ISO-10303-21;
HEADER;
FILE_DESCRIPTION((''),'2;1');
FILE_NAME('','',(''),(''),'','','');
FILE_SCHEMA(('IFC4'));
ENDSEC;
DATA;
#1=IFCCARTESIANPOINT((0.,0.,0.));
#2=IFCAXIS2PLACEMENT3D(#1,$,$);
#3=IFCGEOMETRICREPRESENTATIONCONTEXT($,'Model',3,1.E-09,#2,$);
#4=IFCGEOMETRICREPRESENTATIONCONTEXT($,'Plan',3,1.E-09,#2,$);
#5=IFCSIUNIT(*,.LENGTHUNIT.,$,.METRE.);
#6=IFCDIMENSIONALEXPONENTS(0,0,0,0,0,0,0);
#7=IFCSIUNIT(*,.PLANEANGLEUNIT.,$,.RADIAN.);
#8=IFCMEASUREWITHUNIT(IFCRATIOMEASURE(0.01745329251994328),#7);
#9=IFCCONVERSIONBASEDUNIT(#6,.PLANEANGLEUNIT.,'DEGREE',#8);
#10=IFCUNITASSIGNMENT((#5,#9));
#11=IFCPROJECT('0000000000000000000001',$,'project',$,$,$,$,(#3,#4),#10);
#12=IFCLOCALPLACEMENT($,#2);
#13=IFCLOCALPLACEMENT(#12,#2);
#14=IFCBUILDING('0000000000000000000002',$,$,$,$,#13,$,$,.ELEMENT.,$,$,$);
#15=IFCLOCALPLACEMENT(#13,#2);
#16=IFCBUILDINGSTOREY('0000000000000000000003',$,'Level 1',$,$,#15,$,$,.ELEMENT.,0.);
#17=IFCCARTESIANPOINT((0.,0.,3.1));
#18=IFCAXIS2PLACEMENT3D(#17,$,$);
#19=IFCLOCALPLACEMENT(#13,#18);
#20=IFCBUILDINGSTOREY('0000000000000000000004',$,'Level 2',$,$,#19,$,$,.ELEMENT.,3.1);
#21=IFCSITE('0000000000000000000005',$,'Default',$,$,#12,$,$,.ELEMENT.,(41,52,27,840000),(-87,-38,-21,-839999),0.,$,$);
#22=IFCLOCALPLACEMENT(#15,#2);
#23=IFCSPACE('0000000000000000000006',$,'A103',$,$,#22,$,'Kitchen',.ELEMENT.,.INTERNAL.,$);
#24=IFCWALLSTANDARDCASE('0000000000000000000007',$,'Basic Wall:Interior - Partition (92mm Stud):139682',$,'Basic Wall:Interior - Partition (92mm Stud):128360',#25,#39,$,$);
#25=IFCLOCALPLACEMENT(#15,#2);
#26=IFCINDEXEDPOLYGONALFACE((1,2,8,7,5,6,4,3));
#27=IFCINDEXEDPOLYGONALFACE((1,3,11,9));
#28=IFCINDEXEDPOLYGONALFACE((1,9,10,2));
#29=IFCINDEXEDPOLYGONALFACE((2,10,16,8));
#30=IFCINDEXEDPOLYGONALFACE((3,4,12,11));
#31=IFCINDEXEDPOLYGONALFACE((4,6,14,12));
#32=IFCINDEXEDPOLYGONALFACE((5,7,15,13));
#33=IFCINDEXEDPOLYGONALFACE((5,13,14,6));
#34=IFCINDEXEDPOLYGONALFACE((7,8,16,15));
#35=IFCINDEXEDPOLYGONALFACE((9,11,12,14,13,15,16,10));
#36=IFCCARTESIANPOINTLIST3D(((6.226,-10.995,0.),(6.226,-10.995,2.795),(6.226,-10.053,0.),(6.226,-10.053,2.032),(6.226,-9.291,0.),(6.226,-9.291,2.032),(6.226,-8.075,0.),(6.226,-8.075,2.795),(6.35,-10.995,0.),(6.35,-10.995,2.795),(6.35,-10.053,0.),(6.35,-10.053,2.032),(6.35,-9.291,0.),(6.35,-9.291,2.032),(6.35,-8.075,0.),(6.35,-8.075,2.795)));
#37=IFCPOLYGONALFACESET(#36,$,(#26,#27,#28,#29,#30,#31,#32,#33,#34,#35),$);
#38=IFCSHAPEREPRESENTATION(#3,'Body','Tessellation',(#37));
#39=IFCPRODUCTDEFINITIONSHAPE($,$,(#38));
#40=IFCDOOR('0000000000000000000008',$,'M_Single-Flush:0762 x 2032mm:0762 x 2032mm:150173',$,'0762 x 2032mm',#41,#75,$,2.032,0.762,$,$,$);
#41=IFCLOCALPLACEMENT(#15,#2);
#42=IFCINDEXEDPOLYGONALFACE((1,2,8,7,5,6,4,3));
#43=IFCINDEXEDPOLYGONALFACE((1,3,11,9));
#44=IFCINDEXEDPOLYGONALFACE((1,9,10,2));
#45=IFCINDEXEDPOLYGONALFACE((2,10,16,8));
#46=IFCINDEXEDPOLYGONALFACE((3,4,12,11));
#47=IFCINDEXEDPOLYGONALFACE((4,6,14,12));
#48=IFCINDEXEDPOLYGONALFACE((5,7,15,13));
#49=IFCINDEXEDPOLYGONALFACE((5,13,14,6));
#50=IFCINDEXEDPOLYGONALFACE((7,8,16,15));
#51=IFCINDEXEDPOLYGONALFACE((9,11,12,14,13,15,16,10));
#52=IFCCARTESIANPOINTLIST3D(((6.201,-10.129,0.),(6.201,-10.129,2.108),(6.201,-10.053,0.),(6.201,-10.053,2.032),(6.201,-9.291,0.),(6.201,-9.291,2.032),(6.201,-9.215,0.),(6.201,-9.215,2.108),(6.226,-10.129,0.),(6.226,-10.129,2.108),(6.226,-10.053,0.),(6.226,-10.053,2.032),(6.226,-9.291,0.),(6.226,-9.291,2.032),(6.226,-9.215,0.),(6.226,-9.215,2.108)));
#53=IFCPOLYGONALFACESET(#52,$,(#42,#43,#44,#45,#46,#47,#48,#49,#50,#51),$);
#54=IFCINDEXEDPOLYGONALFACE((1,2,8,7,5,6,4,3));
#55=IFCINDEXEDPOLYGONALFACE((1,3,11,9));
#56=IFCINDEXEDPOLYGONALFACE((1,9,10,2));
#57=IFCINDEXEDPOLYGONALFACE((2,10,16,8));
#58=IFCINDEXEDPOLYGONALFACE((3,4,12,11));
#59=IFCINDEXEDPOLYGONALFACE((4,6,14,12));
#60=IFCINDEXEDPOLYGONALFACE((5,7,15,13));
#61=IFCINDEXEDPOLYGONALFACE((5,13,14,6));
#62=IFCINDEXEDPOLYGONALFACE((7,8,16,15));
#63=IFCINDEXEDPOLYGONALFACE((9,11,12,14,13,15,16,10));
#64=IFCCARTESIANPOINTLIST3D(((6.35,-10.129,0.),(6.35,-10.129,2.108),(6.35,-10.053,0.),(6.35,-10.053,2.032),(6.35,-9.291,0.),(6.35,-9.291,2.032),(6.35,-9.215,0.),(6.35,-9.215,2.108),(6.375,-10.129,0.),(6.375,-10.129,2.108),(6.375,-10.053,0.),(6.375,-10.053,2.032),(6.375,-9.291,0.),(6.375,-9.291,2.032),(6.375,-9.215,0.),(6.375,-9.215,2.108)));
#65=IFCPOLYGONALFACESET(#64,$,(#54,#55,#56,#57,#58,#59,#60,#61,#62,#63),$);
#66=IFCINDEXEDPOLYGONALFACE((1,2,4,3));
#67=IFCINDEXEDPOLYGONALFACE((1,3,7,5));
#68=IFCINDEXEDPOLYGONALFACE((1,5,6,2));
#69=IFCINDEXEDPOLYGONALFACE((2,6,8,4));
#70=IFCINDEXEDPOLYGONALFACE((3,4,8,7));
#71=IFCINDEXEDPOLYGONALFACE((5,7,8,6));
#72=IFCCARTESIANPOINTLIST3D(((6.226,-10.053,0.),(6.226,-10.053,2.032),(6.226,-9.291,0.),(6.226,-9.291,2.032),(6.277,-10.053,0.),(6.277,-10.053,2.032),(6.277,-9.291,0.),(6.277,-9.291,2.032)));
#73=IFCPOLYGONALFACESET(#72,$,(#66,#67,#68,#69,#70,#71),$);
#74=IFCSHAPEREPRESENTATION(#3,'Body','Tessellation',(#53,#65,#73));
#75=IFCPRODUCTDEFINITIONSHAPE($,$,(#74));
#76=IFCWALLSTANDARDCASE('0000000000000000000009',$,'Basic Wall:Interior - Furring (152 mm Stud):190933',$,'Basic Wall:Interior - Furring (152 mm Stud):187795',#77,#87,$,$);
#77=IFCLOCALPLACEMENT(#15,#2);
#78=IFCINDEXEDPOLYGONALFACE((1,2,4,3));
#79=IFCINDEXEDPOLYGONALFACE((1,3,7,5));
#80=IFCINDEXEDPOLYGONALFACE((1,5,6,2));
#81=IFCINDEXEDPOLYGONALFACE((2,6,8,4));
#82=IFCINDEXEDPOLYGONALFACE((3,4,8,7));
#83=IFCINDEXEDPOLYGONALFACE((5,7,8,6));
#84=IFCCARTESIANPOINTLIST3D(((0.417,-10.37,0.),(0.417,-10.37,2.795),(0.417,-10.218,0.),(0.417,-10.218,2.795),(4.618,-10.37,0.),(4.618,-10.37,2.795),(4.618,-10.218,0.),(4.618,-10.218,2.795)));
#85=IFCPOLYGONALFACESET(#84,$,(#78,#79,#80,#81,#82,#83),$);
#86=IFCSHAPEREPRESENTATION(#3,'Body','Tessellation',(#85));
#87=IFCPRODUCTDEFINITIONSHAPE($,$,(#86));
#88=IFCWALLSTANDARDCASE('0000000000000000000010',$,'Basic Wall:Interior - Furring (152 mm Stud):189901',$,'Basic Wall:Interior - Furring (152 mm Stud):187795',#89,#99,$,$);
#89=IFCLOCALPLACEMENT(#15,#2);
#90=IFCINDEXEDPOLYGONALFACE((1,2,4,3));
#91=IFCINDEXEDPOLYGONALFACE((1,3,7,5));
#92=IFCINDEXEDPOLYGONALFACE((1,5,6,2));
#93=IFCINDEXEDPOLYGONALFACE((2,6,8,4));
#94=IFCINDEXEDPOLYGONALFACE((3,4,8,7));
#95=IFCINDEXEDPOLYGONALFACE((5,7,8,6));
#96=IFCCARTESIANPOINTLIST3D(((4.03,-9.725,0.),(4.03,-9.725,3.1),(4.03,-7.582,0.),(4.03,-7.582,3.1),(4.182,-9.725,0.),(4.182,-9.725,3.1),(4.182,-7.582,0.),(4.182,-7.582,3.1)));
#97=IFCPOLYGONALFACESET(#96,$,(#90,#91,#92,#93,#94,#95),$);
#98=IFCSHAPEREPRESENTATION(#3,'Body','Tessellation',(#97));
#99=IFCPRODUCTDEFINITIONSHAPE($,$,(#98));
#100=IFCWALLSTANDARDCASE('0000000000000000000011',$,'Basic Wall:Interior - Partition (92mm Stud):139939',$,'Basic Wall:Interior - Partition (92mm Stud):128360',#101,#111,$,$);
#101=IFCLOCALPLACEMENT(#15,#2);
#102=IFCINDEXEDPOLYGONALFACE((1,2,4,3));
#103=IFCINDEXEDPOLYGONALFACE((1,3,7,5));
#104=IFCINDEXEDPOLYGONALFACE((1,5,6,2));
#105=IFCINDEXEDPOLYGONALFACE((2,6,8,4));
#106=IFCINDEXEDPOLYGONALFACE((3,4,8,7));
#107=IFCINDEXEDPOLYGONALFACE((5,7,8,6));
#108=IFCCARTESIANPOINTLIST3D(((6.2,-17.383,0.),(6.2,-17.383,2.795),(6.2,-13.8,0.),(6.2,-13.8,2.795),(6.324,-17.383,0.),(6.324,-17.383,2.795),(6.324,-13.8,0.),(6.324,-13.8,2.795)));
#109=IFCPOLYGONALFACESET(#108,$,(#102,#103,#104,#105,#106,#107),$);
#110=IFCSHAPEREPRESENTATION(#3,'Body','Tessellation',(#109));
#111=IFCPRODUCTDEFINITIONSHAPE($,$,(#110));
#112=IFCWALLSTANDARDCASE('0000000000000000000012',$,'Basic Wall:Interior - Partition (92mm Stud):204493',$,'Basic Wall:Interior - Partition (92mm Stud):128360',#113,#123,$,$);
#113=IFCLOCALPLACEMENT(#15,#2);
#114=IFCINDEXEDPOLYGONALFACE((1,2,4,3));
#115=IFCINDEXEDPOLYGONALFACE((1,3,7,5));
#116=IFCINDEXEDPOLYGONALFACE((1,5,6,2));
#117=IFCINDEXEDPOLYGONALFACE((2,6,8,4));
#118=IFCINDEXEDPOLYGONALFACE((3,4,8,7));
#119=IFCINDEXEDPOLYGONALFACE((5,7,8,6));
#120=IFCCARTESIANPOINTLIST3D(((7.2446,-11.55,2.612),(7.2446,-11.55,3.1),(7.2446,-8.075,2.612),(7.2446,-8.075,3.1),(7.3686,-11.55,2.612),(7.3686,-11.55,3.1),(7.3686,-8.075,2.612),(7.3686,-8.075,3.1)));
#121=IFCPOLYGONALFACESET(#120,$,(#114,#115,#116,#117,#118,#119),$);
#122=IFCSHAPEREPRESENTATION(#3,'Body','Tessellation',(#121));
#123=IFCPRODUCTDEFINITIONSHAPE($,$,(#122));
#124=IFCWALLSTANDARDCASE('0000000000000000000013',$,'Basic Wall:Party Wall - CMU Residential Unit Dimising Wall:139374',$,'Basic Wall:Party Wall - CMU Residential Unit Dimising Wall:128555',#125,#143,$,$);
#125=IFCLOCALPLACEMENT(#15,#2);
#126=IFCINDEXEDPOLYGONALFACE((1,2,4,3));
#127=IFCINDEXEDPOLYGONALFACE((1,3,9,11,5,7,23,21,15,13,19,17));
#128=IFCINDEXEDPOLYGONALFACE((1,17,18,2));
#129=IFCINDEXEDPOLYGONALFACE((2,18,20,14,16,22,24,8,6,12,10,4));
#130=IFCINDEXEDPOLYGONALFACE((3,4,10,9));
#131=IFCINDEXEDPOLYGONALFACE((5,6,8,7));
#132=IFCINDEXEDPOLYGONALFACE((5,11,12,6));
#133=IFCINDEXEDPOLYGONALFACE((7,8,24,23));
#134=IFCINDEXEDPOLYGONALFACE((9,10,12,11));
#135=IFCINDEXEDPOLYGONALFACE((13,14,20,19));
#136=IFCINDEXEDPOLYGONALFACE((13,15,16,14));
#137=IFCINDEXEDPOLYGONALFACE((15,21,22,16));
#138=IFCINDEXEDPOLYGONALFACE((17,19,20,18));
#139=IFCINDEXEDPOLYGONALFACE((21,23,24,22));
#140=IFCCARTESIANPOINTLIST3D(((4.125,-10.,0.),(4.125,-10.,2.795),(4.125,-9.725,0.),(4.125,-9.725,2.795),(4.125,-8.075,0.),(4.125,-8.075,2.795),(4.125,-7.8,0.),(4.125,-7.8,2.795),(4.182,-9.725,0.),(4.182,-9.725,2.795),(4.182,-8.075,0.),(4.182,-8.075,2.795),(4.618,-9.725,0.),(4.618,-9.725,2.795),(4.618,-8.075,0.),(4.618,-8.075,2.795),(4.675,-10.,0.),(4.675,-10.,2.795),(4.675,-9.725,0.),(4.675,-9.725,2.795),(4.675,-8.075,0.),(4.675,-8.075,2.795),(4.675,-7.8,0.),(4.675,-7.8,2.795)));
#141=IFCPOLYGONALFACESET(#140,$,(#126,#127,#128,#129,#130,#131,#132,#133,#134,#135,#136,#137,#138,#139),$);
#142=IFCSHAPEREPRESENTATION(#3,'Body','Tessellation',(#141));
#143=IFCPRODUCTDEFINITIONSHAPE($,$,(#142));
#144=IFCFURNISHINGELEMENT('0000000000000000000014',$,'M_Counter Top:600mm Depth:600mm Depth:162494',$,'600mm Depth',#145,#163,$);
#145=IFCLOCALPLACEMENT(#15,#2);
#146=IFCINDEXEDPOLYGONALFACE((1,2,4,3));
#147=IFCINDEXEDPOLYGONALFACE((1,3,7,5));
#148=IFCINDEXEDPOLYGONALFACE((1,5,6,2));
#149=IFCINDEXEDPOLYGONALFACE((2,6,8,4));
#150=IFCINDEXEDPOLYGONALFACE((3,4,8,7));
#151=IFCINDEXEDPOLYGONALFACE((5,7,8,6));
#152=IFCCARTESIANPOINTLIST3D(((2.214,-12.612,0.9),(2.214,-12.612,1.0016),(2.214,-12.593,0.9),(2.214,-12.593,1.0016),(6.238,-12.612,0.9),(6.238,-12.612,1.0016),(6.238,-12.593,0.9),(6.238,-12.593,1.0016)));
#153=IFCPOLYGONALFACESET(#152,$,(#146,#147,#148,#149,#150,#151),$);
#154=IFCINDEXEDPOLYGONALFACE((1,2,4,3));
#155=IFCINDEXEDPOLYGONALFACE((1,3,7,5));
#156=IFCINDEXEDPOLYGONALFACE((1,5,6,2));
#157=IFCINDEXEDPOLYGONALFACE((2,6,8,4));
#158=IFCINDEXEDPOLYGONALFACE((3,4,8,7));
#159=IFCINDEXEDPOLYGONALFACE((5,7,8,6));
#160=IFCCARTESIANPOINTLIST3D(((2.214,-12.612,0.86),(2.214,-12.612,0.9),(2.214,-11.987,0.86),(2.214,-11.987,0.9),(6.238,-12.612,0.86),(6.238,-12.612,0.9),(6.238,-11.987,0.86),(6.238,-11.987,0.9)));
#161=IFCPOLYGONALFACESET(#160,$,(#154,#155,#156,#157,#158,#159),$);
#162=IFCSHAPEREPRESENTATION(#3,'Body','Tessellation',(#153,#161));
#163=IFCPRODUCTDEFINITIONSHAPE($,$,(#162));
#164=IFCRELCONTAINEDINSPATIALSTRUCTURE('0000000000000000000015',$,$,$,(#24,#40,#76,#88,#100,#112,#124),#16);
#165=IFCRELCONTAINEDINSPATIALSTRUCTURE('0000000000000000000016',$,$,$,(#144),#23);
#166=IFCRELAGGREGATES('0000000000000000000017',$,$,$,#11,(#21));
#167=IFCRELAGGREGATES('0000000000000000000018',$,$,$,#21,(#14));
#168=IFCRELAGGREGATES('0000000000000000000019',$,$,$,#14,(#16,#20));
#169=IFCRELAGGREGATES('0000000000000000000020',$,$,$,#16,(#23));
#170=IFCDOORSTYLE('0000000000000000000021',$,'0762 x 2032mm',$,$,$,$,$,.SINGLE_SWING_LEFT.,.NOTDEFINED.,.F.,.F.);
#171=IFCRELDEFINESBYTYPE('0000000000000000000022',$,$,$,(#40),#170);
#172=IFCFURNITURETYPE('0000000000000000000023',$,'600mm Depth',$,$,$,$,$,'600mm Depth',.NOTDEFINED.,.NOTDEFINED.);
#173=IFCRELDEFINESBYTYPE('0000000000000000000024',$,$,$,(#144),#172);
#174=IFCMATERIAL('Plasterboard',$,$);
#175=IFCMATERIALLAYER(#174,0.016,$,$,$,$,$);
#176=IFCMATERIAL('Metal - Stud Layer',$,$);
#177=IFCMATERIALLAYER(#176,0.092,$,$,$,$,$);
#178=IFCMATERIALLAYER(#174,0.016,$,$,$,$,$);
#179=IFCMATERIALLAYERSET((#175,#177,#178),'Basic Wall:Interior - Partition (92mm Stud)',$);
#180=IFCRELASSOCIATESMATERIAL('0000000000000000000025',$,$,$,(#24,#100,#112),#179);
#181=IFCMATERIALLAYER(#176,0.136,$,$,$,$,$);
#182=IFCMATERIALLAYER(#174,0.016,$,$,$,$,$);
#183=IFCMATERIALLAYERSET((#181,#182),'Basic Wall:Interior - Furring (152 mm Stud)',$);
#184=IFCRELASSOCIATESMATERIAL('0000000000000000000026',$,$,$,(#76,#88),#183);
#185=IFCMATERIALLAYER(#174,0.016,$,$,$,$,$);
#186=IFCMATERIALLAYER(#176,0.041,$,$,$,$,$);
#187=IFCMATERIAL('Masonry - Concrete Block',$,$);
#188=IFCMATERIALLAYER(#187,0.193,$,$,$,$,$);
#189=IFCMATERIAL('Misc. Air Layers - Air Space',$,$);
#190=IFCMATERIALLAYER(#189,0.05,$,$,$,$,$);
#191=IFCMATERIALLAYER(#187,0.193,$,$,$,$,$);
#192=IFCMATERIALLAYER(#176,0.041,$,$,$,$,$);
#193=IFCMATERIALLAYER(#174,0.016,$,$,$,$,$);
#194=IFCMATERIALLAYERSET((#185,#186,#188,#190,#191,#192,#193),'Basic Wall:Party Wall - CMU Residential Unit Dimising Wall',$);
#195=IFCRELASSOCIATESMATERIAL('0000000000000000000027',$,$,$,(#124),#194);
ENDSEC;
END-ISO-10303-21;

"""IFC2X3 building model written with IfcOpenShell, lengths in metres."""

from ifc_helpers import new_model, entity, si_unit, converted_unit, frame, frame_2d, origin, origin_2d_with_axis, place, context, project, spatial, polyline, rectangle, outline, extrude, clip, bounded_halfspace, source, transform, mapped, material, layer, layer_set, layer_usage, type_object, type_shapes, element, fill, save


model = new_model("IFC2X3")

# Units and contexts
model_context = context("Model", 3, precision=1e-09, world=origin())
plan_context = context("Plan", 3, precision=1e-09, world=origin())
ifc_project = project(units=[si_unit("LENGTHUNIT", "METRE"), converted_unit("PLANEANGLEUNIT", "DEGREE", entity("IfcRatioMeasure", 0.01745329251994328), si_unit("PLANEANGLEUNIT", "RADIAN"), dimensions=[0, 0, 0, 0, 0, 0, 0])], contexts=[model_context, plan_context])

# Site, building, storey
site_placement = place(None, origin())
site = spatial("IfcSite", under=ifc_project, at=site_placement, Name="Default", CompositionType="ELEMENT", RefLatitude=(41, 52, 27, 840000), RefLongitude=(-87, -38, -21, -839999), RefElevation=0.0)
building_placement = place(site_placement, origin())
building = spatial("IfcBuilding", under=site, at=building_placement, CompositionType="ELEMENT")
storey_1_placement = place(building_placement, origin())
storey_1 = spatial("IfcBuildingStorey", under=building, at=storey_1_placement, Name="Level 1", CompositionType="ELEMENT", Elevation=0.0)

# Shared definitions
ifc_material_1 = material(Name="Misc. Air Layers - Air Space")
ifc_material_2 = material(Name="Masonry - Concrete Block")
ifc_material_3 = material(Name="Metal - Stud Layer")
ifc_material_4 = material(Name="Plasterboard")

# Shared definitions
ifc_layer_1 = layer(ifc_material_4, 0.016)
ifc_layer_2 = layer(ifc_material_3, 0.041)
ifc_layer_3 = layer(ifc_material_2, 0.193)
ifc_layer_4 = layer(ifc_material_1, 0.05)
ifc_layer_5 = layer(ifc_material_2, 0.193)
ifc_layer_6 = layer(ifc_material_3, 0.041)
ifc_layer_7 = layer(ifc_material_4, 0.016)
ifc_layer_set_1 = layer_set([ifc_layer_1, ifc_layer_2, ifc_layer_3, ifc_layer_4, ifc_layer_5, ifc_layer_6, ifc_layer_7], Name="Basic Wall:Party Wall - CMU Residential Unit Dimising Wall")
ifc_layer_usage_1 = layer_usage(ifc_layer_set_1, "AXIS2", "NEGATIVE", 0.275)
ifc_layer_8 = layer(ifc_material_4, 0.016)
ifc_layer_9 = layer(ifc_material_3, 0.092)
ifc_layer_10 = layer(ifc_material_4, 0.016)
ifc_layer_set_2 = layer_set([ifc_layer_8, ifc_layer_9, ifc_layer_10], Name="Basic Wall:Interior - Partition (92mm Stud)")
ifc_layer_usage_2 = layer_usage(ifc_layer_set_2, "AXIS2", "NEGATIVE", 0.062)

# Shared definitions
storey_2_placement = place(building_placement, frame((0.0, 0.0, 3.1)))
storey_2 = spatial("IfcBuildingStorey", under=building, at=storey_2_placement, Name="Level 2", CompositionType="ELEMENT", Elevation=3.1)

# Wall, opening, door
wall_1_placement = place(storey_1_placement, frame((6.288, -10.995, 0.0), z_axis=(0.0, 0.0, 1.0), x_axis=(0.0, 1.0, 0.0)))
wall_1 = element("IfcWallStandardCase", 1, at=wall_1_placement, inside=storey_1, material=ifc_layer_usage_2, Name="Basic Wall:Interior - Partition (92mm Stud):139682", ObjectType="Basic Wall:Interior - Partition (92mm Stud):128360", context=model_context, shape_type="SweptSolid", body=[
    extrude(rectangle(XDim=2.92, YDim=0.124, at=frame_2d((1.46, 0.0), x_axis=(-1.0, 0.0))), origin(), (0.0, 0.0, 1.0), 2.795),
])
opening_1_placement = place(wall_1_placement, frame((0.942, -0.062, 0.0)))
opening_1 = element("IfcOpeningElement", 2, at=opening_1_placement, cuts=wall_1, ObjectType="Opening", context=model_context, shape_type="SweptSolid", body=[
    extrude(rectangle(XDim=0.762, YDim=2.032, at=frame_2d((1.016, 0.381), x_axis=(0.0, -1.0))), frame((0.0, 0.0, 0.0), z_axis=(0.0, 1.0, 0.0), x_axis=(0.0, 0.0, 1.0)), (0.0, 0.0, 1.0), 0.124),
])
door_style_1 = type_object("IfcDoorStyle", Name="0762 x 2032mm", ConstructionType="NOTDEFINED", OperationType="SINGLE_SWING_LEFT", ParameterTakesPrecedence=False, Sizeable=False)
shared_shape_1 = source(origin(), model_context, "Body", "SweptSolid", [
    extrude(outline(polyline([(-0.457, -1.073), (0.457, -1.073), (0.457, 1.035), (0.381, 1.035), (0.381, -0.997), (-0.381, -0.997), (-0.381, 1.035), (-0.457, 1.035), (-0.457, -1.073)])), frame((0.381, 0.149, 1.035), z_axis=(0.0, -1.0, 0.0), x_axis=(-1.0, 0.0, 0.0)), (0.0, 0.0, 1.0), 0.025),
    extrude(outline(polyline([(-1.073, -0.457), (1.035, -0.457), (1.035, -0.381), (-0.997, -0.381), (-0.997, 0.381), (1.035, 0.381), (1.035, 0.457), (-1.073, 0.457), (-1.073, -0.457)])), frame((0.381, 0.0, 1.035), z_axis=(0.0, -1.0, 0.0), x_axis=(0.0, 0.0, -1.0)), (0.0, 0.0, 1.0), 0.025),
    extrude(rectangle(XDim=0.762, YDim=0.051, at=origin_2d_with_axis()), frame((0.381, 0.0985, 0.0)), (0.0, 0.0, 1.0), 2.032),
])
type_shapes(door_style_1, [shared_shape_1])
door_1_placement = place(opening_1_placement, origin())
door_1 = element("IfcDoor", 3, at=door_1_placement, inside=storey_1, type_object=door_style_1, Name="M_Single-Flush:0762 x 2032mm:0762 x 2032mm:150173", ObjectType="0762 x 2032mm", OverallHeight=2.032, OverallWidth=0.762, context=model_context, shape_type="MappedRepresentation", body=[
    mapped(shared_shape_1, transform((0.0, 0.0, 0.0), scale=1.0)),
])
fill(opening_1, door_1)

# Walls
ifc_layer_11 = layer(ifc_material_3, 0.136)
ifc_layer_12 = layer(ifc_material_4, 0.016)
ifc_layer_set_3 = layer_set([ifc_layer_11, ifc_layer_12], Name="Basic Wall:Interior - Furring (152 mm Stud)")
ifc_layer_usage_3 = layer_usage(ifc_layer_set_3, "AXIS2", "NEGATIVE", 0.076)
wall_2_placement = place(storey_1_placement, frame((0.417, -10.294, 0.0)))
element("IfcWallStandardCase", 4, at=wall_2_placement, inside=storey_1, material=ifc_layer_usage_3, Name="Basic Wall:Interior - Furring (152 mm Stud):190933", ObjectType="Basic Wall:Interior - Furring (152 mm Stud):187795", context=model_context, shape_type="SweptSolid", body=[
    extrude(rectangle(XDim=4.201, YDim=0.152, at=frame_2d((2.1005, 0.0), x_axis=(-1.0, 0.0))), origin(), (0.0, 0.0, 1.0), 2.795),
])
ifc_layer_usage_4 = layer_usage(ifc_layer_set_3, "AXIS2", "POSITIVE", -0.076)
wall_3_placement = place(storey_1_placement, frame((4.106, -9.725, 0.0), z_axis=(0.0, 0.0, 1.0), x_axis=(0.0, 1.0, 0.0)))
element("IfcWallStandardCase", 5, at=wall_3_placement, inside=storey_1, material=ifc_layer_usage_4, Name="Basic Wall:Interior - Furring (152 mm Stud):189901", ObjectType="Basic Wall:Interior - Furring (152 mm Stud):187795", context=model_context, shape_type="SweptSolid", body=[
    extrude(rectangle(XDim=2.143, YDim=0.152, at=frame_2d((1.0715, 0.0), x_axis=(-1.0, 0.0))), origin(), (0.0, 0.0, 1.0), 3.1),
])
wall_4_placement = place(storey_1_placement, frame((6.262, -13.8, 0.0), z_axis=(0.0, 0.0, 1.0), x_axis=(0.0, -1.0, 0.0)))
element("IfcWallStandardCase", 6, at=wall_4_placement, inside=storey_1, material=ifc_layer_usage_2, Name="Basic Wall:Interior - Partition (92mm Stud):139939", ObjectType="Basic Wall:Interior - Partition (92mm Stud):128360", context=model_context, shape_type="SweptSolid", body=[
    extrude(rectangle(XDim=3.583, YDim=0.124, at=frame_2d((1.7915, 0.0), x_axis=(-1.0, 0.0))), origin(), (0.0, 0.0, 1.0), 2.795),
])
wall_5_placement = place(storey_1_placement, frame((7.3066, -11.55, 2.612), z_axis=(0.0, 0.0, 1.0), x_axis=(0.0, 1.0, 0.0)))
element("IfcWallStandardCase", 7, at=wall_5_placement, inside=storey_1, material=ifc_layer_usage_2, Name="Basic Wall:Interior - Partition (92mm Stud):204493", ObjectType="Basic Wall:Interior - Partition (92mm Stud):128360", context=model_context, shape_type="SweptSolid", body=[
    extrude(rectangle(XDim=3.475, YDim=0.124, at=frame_2d((1.7375, 0.0), x_axis=(-1.0, 0.0))), origin(), (0.0, 0.0, 1.0), 0.488),
])
wall_6_placement = place(storey_1_placement, frame((4.4, -10.0, 0.0), z_axis=(0.0, 0.0, 1.0), x_axis=(0.0, 1.0, 0.0)))
element("IfcWallStandardCase", 8, at=wall_6_placement, inside=storey_1, material=ifc_layer_usage_1, Name="Basic Wall:Party Wall - CMU Residential Unit Dimising Wall:139374", ObjectType="Basic Wall:Party Wall - CMU Residential Unit Dimising Wall:128555", context=model_context, shape_type="Clipping", body=[
    clip(clip(extrude(rectangle(XDim=2.2, YDim=0.55, at=frame_2d((1.1, 0.0), x_axis=(-1.0, 0.0))), origin(), (0.0, 0.0, 1.0), 2.795), bounded_halfspace(frame((1.925, 0.218, 0.0), z_axis=(0.0, -1.0, 0.0), x_axis=(1.0, 0.0, 0.0)), True, frame((1.925, 0.218, 0.0), z_axis=(0.0, -1.0, 0.0), x_axis=(1.0, 0.0, 0.0)), polyline([(0.0, 0.0), (0.0, 2.795), (-1.65, 2.795), (-1.65, 0.0), (0.0, 0.0)]))), bounded_halfspace(frame((0.275, -0.218, 0.0), z_axis=(0.0, 1.0, 0.0), x_axis=(-1.0, 0.0, 0.0)), True, frame((0.275, -0.218, 0.0), z_axis=(0.0, 1.0, 0.0), x_axis=(-1.0, 0.0, 0.0)), polyline([(0.0, 0.0), (0.0, 2.795), (-1.65, 2.795), (-1.65, 0.0), (0.0, 0.0)]))),
])

# Shared definitions
space_1_placement = place(storey_1_placement, origin())
space_1 = spatial("IfcSpace", under=storey_1, at=space_1_placement, Name="A103", LongName="Kitchen", CompositionType="ELEMENT", InteriorOrExteriorSpace="INTERNAL")

# Furnishing element
furniture_type_1 = type_object("IfcFurnitureType", Name="600mm Depth", ElementType="600mm Depth", AssemblyPlace="NOTDEFINED")
shared_shape_2 = source(origin(), model_context, "Body", "SweptSolid", [
    extrude(rectangle(XDim=0.0191, YDim=4.024, at=origin_2d_with_axis()), frame((0.8115, -0.0095, 0.9), z_axis=(0.0, 0.0, 1.0), x_axis=(0.0, -1.0, 0.0)), (0.0, 0.0, 1.0), 0.1016),
    extrude(rectangle(XDim=4.024, YDim=0.625, at=origin_2d_with_axis()), frame((0.8115, -0.3125, 0.86), z_axis=(0.0, 0.0, 1.0), x_axis=(-1.0, 0.0, 0.0)), (0.0, 0.0, 1.0), 0.04),
])
type_shapes(furniture_type_1, [shared_shape_2])
furnishing_1_placement = place(space_1_placement, frame((5.0375, -12.612, 0.0), z_axis=(0.0, 0.0, 1.0), x_axis=(-1.0, 0.0, 0.0)))
element("IfcFurnishingElement", 9, at=furnishing_1_placement, inside=space_1, type_object=furniture_type_1, Name="M_Counter Top:600mm Depth:600mm Depth:162494", ObjectType="600mm Depth", context=model_context, shape_type="MappedRepresentation", body=[
    mapped(shared_shape_2, transform((0.0, 0.0, 0.0), scale=1.0)),
])

save(model, "model.ifc")
